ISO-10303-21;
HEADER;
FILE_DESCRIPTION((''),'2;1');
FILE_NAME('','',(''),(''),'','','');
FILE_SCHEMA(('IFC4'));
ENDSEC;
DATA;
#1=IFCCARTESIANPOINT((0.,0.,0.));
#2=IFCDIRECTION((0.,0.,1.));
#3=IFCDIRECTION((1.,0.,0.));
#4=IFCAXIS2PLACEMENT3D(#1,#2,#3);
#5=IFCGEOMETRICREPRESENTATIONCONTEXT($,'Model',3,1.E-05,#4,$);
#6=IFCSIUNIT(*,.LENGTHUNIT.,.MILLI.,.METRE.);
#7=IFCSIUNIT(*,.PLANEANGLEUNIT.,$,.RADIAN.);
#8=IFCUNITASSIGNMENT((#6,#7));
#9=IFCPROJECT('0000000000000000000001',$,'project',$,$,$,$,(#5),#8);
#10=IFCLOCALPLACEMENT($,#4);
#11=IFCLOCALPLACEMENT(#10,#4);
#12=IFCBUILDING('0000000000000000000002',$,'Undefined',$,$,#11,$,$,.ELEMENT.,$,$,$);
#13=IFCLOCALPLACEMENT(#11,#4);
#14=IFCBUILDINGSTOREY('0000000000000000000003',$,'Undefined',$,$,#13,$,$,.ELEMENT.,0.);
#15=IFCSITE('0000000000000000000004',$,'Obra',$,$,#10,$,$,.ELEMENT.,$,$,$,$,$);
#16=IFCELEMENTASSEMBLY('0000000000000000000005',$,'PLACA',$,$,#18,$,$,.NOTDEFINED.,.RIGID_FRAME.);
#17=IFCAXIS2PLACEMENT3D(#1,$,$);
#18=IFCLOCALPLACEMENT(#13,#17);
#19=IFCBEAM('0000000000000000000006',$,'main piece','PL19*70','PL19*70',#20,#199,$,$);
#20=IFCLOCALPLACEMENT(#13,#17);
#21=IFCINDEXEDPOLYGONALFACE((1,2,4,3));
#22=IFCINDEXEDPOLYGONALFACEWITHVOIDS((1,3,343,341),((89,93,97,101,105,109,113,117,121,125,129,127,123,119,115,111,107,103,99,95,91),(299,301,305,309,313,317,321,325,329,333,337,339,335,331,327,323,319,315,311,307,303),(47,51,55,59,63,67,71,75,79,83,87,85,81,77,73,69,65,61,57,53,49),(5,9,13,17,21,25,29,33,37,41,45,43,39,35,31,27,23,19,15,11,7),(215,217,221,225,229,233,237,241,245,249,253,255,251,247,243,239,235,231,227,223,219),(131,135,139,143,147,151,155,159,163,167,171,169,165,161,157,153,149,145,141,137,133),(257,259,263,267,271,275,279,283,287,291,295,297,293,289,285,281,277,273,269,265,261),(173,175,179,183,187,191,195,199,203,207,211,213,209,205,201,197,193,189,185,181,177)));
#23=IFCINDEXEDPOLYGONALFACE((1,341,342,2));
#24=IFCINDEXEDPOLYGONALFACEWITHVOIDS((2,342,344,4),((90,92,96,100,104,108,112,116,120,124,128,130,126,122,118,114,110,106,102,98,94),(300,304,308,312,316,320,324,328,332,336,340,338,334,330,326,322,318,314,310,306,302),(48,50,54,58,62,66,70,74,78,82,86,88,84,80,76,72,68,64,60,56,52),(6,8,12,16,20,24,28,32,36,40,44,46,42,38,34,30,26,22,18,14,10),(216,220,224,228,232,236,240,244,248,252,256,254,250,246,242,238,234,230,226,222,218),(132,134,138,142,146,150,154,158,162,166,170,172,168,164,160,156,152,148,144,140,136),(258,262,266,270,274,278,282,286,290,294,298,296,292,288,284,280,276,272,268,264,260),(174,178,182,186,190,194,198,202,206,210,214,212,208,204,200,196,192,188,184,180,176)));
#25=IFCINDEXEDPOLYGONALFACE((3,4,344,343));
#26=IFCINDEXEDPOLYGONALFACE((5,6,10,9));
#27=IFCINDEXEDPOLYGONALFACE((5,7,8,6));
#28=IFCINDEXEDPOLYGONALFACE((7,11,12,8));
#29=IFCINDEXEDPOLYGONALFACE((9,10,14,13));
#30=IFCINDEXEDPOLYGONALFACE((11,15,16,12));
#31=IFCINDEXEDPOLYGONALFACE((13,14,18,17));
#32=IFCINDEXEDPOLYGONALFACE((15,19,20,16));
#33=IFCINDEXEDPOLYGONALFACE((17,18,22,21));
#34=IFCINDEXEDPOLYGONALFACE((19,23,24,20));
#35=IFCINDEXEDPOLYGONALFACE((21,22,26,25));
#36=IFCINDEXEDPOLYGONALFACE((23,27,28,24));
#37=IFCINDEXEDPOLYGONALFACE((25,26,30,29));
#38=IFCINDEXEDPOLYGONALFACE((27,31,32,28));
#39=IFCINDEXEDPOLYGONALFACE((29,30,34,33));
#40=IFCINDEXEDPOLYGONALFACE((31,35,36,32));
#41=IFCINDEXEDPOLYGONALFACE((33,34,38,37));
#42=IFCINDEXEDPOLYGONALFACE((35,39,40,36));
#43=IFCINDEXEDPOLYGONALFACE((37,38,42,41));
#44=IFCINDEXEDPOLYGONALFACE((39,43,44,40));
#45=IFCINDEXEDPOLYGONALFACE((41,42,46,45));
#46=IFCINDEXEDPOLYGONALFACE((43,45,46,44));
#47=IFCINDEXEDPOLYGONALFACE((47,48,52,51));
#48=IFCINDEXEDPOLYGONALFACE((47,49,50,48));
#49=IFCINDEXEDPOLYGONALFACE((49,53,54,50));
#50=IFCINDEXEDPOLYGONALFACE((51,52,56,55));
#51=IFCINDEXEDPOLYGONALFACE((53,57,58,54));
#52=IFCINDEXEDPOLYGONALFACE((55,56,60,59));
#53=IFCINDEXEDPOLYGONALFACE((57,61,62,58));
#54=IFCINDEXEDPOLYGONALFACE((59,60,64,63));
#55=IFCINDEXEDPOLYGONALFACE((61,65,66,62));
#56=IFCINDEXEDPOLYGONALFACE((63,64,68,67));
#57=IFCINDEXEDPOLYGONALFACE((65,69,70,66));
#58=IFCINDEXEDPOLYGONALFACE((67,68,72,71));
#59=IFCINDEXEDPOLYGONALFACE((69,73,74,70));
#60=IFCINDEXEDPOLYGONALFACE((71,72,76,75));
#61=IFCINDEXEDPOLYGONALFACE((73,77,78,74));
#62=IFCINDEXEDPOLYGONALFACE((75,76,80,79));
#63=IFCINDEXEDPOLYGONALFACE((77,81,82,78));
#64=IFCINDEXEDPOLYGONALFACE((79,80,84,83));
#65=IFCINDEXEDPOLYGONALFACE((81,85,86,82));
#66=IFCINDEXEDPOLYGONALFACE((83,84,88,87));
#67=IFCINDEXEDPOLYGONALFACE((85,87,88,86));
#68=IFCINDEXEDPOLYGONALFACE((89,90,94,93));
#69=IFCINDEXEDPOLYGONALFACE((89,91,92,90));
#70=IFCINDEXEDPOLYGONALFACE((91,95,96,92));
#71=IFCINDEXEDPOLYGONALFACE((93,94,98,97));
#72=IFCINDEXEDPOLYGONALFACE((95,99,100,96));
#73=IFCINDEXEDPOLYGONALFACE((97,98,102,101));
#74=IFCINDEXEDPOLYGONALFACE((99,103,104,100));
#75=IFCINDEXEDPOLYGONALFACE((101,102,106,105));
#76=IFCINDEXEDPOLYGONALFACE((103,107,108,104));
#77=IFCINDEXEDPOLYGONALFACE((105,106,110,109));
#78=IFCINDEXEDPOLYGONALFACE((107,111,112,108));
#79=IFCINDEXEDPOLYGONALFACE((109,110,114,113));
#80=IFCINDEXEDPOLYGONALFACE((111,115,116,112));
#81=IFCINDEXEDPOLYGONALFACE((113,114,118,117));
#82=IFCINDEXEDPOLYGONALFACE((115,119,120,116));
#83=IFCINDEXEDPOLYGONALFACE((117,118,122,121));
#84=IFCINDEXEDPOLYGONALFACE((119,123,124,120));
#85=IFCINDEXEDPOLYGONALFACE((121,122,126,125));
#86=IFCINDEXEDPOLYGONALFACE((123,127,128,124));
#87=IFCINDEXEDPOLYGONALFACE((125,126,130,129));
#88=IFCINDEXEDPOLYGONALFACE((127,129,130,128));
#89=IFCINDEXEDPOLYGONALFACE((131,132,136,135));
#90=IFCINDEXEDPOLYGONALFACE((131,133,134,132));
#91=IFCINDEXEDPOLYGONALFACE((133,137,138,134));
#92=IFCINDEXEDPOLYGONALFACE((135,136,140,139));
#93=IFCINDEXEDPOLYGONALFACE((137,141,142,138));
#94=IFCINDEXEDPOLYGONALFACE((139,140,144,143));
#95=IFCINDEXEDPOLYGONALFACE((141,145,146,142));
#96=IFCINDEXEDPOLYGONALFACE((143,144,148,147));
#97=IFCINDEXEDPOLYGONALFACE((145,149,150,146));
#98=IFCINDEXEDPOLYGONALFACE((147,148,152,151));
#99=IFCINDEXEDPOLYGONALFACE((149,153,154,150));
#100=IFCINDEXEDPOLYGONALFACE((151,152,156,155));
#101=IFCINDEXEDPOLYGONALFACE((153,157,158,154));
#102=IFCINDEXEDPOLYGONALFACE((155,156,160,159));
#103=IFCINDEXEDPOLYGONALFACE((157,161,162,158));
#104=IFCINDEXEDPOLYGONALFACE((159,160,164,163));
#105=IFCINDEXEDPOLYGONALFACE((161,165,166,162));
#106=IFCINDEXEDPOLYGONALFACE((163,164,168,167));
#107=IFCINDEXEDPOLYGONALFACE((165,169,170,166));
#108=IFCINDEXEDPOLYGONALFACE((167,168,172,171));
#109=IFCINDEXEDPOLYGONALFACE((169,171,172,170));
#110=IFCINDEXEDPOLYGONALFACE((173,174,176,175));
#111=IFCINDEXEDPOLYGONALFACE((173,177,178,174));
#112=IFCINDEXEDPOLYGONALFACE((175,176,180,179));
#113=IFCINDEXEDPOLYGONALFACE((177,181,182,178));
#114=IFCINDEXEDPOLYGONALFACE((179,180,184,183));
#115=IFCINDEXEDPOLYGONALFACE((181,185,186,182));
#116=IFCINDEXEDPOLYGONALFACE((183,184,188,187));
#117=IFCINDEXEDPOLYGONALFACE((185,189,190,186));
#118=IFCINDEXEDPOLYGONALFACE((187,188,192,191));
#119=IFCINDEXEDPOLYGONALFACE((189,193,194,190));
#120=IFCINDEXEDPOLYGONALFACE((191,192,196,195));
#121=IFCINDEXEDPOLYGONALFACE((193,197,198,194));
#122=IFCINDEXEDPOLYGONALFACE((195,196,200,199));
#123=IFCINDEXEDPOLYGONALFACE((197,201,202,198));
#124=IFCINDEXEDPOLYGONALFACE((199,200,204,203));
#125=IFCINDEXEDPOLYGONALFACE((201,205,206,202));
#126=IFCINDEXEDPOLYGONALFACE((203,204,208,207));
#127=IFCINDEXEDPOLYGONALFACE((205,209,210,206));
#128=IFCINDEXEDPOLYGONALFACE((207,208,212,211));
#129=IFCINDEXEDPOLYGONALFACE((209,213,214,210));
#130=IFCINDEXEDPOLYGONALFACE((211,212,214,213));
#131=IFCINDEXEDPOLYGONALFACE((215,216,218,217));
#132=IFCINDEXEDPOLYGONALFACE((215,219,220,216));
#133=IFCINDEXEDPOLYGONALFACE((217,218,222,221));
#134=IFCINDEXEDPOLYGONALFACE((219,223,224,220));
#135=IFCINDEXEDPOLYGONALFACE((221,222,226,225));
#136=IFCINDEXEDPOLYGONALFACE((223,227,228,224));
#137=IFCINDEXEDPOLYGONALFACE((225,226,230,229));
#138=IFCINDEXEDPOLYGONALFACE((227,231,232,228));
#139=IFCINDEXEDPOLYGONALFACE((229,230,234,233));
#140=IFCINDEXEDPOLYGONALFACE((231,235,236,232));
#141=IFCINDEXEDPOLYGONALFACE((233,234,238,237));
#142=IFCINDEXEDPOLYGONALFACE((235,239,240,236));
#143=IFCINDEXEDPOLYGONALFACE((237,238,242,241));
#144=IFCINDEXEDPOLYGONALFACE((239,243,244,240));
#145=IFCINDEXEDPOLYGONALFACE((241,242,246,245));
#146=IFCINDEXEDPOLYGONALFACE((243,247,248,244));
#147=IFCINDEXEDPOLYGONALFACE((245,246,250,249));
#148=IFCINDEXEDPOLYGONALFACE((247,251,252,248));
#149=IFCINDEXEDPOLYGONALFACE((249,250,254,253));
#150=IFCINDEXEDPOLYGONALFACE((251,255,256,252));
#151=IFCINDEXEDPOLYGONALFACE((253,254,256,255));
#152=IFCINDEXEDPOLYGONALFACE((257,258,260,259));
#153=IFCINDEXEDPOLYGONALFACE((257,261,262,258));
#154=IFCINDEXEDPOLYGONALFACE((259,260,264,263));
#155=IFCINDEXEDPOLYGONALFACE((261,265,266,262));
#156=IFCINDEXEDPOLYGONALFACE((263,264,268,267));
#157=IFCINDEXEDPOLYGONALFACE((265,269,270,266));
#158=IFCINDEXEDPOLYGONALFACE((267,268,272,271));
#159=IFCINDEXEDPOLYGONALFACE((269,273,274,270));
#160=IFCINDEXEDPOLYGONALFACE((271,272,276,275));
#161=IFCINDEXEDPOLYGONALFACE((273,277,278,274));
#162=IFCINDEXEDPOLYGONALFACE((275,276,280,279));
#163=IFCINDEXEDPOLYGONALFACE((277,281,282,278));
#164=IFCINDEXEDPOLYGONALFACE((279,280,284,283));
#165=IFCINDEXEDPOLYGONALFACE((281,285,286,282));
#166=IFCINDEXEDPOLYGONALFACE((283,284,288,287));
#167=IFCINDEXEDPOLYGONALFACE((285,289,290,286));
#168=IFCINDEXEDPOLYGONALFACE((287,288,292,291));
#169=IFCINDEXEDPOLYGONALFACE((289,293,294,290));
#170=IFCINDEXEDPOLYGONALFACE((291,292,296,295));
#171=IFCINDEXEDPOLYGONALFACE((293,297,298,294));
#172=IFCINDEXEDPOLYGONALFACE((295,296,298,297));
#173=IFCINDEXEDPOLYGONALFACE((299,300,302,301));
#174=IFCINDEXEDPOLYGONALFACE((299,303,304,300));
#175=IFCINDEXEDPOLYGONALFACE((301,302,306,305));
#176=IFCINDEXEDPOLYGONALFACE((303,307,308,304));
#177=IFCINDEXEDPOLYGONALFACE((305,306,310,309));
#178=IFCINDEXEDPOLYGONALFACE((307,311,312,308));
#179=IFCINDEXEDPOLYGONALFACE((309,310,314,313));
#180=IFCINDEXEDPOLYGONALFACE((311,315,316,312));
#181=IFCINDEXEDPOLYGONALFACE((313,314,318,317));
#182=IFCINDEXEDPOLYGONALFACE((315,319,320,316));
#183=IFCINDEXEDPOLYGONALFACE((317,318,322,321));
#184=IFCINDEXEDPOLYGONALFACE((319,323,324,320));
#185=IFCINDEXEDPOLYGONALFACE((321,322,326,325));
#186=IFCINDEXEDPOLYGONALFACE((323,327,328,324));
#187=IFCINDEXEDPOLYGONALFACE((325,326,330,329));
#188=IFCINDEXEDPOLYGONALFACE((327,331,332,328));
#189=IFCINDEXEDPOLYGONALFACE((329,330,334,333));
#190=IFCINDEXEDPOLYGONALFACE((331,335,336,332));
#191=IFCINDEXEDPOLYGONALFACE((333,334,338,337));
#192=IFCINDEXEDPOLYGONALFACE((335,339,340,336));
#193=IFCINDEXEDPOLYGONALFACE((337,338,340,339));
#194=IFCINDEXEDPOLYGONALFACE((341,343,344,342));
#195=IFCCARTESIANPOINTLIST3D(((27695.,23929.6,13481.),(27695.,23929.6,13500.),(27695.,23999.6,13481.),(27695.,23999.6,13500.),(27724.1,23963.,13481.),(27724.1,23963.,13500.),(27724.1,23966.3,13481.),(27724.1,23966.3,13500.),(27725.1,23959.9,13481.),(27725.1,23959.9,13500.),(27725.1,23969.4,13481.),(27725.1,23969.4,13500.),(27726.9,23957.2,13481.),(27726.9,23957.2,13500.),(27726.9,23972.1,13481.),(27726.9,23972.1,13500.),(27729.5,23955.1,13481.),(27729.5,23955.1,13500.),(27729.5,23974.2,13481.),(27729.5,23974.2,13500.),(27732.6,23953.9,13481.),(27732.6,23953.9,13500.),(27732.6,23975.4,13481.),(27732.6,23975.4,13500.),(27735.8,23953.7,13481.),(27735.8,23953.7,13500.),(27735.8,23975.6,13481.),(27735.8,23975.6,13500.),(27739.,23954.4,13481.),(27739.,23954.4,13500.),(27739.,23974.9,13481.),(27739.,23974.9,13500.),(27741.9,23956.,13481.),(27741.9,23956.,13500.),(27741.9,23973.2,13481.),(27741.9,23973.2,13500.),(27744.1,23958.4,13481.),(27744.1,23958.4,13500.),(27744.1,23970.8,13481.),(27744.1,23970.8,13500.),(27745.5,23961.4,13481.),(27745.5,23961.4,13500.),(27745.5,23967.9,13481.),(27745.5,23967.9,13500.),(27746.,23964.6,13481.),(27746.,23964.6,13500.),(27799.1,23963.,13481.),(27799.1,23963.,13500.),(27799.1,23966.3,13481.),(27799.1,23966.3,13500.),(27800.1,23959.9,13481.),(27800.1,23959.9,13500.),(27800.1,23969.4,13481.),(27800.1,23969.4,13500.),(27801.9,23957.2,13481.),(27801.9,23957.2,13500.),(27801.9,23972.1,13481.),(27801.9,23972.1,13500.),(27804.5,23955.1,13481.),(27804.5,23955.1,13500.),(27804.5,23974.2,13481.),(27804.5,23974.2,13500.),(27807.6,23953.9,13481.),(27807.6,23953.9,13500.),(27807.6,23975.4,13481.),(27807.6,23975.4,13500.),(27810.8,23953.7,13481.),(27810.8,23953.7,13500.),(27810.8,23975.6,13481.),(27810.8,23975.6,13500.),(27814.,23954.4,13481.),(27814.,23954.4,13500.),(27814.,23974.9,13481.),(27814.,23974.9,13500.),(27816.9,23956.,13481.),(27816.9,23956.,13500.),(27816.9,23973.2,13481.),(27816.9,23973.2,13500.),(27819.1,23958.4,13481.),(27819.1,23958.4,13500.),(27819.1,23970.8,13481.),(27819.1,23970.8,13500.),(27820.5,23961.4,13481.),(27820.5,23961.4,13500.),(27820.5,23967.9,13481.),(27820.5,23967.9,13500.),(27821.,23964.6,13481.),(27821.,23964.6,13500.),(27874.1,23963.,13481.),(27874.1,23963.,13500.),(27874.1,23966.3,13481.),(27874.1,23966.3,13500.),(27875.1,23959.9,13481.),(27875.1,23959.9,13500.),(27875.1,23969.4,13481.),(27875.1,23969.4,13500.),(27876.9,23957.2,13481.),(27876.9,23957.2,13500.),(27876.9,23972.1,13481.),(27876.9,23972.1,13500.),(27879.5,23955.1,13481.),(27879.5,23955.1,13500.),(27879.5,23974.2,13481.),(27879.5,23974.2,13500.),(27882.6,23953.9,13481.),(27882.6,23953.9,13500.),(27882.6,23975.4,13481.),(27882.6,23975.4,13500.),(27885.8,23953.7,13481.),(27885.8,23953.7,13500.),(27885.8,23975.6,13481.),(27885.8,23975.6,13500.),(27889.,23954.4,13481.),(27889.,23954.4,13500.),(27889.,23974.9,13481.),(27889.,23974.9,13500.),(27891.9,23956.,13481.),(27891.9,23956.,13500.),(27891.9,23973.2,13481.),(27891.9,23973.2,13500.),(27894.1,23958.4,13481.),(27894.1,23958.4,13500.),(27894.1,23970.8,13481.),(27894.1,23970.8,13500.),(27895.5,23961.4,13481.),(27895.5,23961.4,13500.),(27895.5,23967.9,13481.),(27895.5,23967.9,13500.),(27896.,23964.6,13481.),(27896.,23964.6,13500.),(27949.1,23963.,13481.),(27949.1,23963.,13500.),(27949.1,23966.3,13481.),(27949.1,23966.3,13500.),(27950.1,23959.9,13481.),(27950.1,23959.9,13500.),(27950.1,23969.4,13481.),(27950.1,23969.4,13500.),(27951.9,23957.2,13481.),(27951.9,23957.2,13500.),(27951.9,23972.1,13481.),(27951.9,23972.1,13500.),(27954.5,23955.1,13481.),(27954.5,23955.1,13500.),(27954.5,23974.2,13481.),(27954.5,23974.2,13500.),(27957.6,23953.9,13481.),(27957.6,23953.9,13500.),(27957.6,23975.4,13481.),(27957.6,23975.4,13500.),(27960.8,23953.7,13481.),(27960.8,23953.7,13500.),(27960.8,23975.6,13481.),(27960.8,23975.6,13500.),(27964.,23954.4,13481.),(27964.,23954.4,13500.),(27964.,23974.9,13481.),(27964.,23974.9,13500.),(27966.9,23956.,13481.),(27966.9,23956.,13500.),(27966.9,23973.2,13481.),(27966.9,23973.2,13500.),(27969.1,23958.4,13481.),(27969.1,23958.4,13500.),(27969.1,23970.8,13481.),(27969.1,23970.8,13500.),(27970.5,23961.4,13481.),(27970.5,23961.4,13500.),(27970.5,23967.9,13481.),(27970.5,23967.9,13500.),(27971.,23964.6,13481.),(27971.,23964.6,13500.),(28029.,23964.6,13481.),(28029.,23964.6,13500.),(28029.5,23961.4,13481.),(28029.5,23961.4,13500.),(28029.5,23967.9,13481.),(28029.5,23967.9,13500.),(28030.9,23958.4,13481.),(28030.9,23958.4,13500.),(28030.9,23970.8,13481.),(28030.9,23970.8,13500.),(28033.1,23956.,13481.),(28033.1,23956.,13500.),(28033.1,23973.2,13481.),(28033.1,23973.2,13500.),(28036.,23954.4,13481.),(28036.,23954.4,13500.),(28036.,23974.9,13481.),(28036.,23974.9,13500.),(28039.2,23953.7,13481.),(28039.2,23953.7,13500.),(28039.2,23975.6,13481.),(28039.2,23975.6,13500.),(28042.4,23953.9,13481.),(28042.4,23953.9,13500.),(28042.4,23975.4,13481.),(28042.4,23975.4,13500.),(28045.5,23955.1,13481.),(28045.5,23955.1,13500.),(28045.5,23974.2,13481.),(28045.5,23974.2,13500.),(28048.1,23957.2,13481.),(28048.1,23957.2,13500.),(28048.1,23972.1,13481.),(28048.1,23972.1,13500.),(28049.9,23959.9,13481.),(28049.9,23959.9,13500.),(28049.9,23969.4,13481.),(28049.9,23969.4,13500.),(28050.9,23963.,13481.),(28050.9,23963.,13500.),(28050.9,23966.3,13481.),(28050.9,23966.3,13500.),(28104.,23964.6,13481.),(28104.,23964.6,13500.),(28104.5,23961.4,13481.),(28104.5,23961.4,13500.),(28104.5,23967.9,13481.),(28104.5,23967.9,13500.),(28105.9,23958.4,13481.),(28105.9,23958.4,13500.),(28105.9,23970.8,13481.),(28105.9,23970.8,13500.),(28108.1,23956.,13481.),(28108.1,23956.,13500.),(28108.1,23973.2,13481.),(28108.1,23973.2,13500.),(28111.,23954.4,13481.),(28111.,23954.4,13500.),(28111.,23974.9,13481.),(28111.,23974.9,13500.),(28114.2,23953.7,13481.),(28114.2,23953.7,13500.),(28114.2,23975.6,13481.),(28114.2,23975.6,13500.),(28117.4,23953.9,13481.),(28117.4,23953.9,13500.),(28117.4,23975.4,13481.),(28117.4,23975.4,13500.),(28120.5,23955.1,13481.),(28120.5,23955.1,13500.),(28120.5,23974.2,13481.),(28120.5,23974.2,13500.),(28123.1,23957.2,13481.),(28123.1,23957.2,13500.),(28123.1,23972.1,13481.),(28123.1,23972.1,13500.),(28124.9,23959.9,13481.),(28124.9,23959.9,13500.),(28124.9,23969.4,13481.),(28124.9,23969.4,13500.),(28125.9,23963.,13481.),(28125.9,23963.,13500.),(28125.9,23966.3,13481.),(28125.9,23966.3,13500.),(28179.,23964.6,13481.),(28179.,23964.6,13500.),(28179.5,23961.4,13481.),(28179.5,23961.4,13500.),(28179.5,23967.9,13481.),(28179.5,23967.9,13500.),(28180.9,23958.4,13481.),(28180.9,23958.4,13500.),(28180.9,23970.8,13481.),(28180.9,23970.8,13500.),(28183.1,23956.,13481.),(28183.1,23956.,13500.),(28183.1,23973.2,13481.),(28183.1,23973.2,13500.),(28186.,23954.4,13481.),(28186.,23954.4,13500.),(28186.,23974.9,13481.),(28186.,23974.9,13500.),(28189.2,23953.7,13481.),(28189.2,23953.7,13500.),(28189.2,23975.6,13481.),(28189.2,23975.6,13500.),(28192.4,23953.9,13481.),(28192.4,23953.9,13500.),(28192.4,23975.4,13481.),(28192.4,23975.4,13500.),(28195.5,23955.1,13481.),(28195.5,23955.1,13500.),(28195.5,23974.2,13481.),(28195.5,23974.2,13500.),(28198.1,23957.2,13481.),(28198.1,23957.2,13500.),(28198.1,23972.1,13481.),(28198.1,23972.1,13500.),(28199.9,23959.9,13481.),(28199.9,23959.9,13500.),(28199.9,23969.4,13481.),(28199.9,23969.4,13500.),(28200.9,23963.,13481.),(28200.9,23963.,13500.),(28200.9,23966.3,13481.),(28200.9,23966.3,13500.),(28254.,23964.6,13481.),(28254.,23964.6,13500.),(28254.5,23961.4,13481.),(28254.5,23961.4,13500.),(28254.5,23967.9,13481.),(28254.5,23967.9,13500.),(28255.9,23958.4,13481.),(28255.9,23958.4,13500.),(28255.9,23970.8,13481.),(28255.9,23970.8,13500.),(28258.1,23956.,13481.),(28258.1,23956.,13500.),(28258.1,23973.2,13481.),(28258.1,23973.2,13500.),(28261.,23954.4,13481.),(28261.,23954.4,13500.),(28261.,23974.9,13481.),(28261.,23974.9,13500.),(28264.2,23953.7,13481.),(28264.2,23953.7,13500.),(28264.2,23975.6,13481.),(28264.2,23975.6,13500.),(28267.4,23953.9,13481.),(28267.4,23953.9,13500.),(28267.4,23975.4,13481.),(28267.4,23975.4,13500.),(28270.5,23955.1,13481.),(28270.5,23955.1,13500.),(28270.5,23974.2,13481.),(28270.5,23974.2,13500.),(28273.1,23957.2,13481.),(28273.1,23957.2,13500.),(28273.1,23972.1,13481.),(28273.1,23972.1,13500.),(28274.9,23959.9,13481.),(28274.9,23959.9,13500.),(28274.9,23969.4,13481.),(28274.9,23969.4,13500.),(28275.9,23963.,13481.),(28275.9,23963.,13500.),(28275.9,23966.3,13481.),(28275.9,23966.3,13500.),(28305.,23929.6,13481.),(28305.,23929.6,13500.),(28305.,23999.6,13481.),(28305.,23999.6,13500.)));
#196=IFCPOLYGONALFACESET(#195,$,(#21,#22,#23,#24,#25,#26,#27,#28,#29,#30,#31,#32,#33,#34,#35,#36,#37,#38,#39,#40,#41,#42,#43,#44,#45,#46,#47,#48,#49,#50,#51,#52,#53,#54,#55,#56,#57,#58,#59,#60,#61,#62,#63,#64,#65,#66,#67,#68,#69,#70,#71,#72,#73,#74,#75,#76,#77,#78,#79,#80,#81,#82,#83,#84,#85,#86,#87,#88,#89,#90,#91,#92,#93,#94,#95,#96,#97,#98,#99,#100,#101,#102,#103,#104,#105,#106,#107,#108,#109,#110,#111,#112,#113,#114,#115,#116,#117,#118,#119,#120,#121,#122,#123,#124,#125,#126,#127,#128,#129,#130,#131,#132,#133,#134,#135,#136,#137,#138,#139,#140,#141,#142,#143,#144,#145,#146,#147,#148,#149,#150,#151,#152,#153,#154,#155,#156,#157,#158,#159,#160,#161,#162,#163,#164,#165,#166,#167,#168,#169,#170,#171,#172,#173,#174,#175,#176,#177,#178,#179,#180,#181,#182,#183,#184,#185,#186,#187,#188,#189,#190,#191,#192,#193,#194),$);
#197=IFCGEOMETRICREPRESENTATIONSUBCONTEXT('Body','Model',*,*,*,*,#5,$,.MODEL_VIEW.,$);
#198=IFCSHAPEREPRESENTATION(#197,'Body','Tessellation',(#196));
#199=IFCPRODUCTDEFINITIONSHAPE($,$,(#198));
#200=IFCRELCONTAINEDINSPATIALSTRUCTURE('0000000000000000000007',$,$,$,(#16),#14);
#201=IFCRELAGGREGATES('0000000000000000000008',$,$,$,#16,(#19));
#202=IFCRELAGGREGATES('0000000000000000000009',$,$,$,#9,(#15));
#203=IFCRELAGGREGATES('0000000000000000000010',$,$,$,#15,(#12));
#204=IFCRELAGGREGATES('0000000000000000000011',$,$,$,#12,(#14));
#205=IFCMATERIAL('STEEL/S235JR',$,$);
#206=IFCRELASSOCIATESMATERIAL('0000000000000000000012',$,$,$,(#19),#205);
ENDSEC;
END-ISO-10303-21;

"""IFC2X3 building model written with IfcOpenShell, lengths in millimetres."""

from ifc_helpers import new_model, si_unit, frame, origin_with_axes, origin_2d_with_axis, place, context, subcontext, project, spatial, rectangle, circle, extrude, source, transform, mapped, material, element, aggregate, save


model = new_model("IFC2X3")

# Units and contexts
model_context = context("Model", 3, precision=1e-05, world=origin_with_axes())
body_context = subcontext(model_context, "Body", "Model", "MODEL_VIEW")
ifc_project = project(units=[si_unit("LENGTHUNIT", "METRE", prefix="MILLI"), si_unit("PLANEANGLEUNIT", "RADIAN")], contexts=[model_context])

# Site, building, storey
site_placement = place(None, origin_with_axes())
site = spatial("IfcSite", under=ifc_project, at=site_placement, Name="Obra", CompositionType="ELEMENT")
building_placement = place(site_placement, origin_with_axes())
building = spatial("IfcBuilding", under=site, at=building_placement, Name="Undefined", CompositionType="ELEMENT")
storey_placement = place(building_placement, origin_with_axes())
storey = spatial("IfcBuildingStorey", under=building, at=storey_placement, Name="Undefined", CompositionType="ELEMENT", Elevation=0.0)

# Shared definitions
ifc_material_1 = material(Name="STEEL/S235JR")

# Element assembly, beam, openings
assembly_1_placement = place(storey_placement, origin_with_axes())
assembly_1 = element("IfcElementAssembly", 1, at=assembly_1_placement, inside=storey, Name="PLACA", AssemblyPlace="NOTDEFINED", PredefinedType="RIGID_FRAME")
beam_1_placement = place(assembly_1_placement, frame((28305.0, 23964.6, 13490.5), z_axis=(0.0, -1.0, 0.0), x_axis=(-1.0, 0.0, 0.0)))
beam_1 = element("IfcBeam", 2, at=beam_1_placement, material=ifc_material_1, Name="main piece", Description="PL19*70", ObjectType="PL19*70", context=body_context, shape_type="SweptSolid", body=[
    extrude(rectangle(XDim=19.0, YDim=70.0, at=origin_2d_with_axis()), frame((610.0, 0.0, 0.0), z_axis=(-1.0, 0.0, 0.0), x_axis=(0.0, -1.0, 0.0)), (0.0, 0.0, 1.0), 610.0),
])
shared_shape_1 = source(origin_with_axes(), body_context, "Body", "SweptSolid", [
    extrude(circle(Radius=11.0, at=origin_2d_with_axis()), frame((0.0, -19.1, 0.0), z_axis=(0.0, 1.0, 0.0), x_axis=(1.0, 0.0, 0.0)), (0.0, 0.0, 1.0), 19.2),
])
opening_1_placement = place(assembly_1_placement, frame((28265.0, 23964.6, 13481.0), z_axis=(0.0, -1.0, 0.0), x_axis=(-1.0, 0.0, 0.0)))
element("IfcOpeningElement", 3, at=opening_1_placement, cuts=beam_1, ObjectType="Opening", context=body_context, shape_type="MappedRepresentation", body=[
    mapped(shared_shape_1, transform((0.0, 0.0, 0.0))),
    mapped(shared_shape_1, transform((75.0, 0.0, 0.0))),
    mapped(shared_shape_1, transform((150.0, 0.0, 0.0))),
    mapped(shared_shape_1, transform((225.0, 0.0, 0.0))),
])
opening_2_placement = place(assembly_1_placement, frame((27735.0, 23964.6, 13481.0), z_axis=(0.0, 1.0, 0.0), x_axis=(1.0, 0.0, 0.0)))
element("IfcOpeningElement", 4, at=opening_2_placement, cuts=beam_1, ObjectType="Opening", context=body_context, shape_type="MappedRepresentation", body=[
    mapped(shared_shape_1, transform((0.0, 0.0, 0.0))),
    mapped(shared_shape_1, transform((75.0, 0.0, 0.0))),
    mapped(shared_shape_1, transform((150.0, 0.0, 0.0))),
    mapped(shared_shape_1, transform((225.0, 0.0, 0.0))),
])

aggregate(assembly_1, [beam_1])

save(model, "model.ifc")
